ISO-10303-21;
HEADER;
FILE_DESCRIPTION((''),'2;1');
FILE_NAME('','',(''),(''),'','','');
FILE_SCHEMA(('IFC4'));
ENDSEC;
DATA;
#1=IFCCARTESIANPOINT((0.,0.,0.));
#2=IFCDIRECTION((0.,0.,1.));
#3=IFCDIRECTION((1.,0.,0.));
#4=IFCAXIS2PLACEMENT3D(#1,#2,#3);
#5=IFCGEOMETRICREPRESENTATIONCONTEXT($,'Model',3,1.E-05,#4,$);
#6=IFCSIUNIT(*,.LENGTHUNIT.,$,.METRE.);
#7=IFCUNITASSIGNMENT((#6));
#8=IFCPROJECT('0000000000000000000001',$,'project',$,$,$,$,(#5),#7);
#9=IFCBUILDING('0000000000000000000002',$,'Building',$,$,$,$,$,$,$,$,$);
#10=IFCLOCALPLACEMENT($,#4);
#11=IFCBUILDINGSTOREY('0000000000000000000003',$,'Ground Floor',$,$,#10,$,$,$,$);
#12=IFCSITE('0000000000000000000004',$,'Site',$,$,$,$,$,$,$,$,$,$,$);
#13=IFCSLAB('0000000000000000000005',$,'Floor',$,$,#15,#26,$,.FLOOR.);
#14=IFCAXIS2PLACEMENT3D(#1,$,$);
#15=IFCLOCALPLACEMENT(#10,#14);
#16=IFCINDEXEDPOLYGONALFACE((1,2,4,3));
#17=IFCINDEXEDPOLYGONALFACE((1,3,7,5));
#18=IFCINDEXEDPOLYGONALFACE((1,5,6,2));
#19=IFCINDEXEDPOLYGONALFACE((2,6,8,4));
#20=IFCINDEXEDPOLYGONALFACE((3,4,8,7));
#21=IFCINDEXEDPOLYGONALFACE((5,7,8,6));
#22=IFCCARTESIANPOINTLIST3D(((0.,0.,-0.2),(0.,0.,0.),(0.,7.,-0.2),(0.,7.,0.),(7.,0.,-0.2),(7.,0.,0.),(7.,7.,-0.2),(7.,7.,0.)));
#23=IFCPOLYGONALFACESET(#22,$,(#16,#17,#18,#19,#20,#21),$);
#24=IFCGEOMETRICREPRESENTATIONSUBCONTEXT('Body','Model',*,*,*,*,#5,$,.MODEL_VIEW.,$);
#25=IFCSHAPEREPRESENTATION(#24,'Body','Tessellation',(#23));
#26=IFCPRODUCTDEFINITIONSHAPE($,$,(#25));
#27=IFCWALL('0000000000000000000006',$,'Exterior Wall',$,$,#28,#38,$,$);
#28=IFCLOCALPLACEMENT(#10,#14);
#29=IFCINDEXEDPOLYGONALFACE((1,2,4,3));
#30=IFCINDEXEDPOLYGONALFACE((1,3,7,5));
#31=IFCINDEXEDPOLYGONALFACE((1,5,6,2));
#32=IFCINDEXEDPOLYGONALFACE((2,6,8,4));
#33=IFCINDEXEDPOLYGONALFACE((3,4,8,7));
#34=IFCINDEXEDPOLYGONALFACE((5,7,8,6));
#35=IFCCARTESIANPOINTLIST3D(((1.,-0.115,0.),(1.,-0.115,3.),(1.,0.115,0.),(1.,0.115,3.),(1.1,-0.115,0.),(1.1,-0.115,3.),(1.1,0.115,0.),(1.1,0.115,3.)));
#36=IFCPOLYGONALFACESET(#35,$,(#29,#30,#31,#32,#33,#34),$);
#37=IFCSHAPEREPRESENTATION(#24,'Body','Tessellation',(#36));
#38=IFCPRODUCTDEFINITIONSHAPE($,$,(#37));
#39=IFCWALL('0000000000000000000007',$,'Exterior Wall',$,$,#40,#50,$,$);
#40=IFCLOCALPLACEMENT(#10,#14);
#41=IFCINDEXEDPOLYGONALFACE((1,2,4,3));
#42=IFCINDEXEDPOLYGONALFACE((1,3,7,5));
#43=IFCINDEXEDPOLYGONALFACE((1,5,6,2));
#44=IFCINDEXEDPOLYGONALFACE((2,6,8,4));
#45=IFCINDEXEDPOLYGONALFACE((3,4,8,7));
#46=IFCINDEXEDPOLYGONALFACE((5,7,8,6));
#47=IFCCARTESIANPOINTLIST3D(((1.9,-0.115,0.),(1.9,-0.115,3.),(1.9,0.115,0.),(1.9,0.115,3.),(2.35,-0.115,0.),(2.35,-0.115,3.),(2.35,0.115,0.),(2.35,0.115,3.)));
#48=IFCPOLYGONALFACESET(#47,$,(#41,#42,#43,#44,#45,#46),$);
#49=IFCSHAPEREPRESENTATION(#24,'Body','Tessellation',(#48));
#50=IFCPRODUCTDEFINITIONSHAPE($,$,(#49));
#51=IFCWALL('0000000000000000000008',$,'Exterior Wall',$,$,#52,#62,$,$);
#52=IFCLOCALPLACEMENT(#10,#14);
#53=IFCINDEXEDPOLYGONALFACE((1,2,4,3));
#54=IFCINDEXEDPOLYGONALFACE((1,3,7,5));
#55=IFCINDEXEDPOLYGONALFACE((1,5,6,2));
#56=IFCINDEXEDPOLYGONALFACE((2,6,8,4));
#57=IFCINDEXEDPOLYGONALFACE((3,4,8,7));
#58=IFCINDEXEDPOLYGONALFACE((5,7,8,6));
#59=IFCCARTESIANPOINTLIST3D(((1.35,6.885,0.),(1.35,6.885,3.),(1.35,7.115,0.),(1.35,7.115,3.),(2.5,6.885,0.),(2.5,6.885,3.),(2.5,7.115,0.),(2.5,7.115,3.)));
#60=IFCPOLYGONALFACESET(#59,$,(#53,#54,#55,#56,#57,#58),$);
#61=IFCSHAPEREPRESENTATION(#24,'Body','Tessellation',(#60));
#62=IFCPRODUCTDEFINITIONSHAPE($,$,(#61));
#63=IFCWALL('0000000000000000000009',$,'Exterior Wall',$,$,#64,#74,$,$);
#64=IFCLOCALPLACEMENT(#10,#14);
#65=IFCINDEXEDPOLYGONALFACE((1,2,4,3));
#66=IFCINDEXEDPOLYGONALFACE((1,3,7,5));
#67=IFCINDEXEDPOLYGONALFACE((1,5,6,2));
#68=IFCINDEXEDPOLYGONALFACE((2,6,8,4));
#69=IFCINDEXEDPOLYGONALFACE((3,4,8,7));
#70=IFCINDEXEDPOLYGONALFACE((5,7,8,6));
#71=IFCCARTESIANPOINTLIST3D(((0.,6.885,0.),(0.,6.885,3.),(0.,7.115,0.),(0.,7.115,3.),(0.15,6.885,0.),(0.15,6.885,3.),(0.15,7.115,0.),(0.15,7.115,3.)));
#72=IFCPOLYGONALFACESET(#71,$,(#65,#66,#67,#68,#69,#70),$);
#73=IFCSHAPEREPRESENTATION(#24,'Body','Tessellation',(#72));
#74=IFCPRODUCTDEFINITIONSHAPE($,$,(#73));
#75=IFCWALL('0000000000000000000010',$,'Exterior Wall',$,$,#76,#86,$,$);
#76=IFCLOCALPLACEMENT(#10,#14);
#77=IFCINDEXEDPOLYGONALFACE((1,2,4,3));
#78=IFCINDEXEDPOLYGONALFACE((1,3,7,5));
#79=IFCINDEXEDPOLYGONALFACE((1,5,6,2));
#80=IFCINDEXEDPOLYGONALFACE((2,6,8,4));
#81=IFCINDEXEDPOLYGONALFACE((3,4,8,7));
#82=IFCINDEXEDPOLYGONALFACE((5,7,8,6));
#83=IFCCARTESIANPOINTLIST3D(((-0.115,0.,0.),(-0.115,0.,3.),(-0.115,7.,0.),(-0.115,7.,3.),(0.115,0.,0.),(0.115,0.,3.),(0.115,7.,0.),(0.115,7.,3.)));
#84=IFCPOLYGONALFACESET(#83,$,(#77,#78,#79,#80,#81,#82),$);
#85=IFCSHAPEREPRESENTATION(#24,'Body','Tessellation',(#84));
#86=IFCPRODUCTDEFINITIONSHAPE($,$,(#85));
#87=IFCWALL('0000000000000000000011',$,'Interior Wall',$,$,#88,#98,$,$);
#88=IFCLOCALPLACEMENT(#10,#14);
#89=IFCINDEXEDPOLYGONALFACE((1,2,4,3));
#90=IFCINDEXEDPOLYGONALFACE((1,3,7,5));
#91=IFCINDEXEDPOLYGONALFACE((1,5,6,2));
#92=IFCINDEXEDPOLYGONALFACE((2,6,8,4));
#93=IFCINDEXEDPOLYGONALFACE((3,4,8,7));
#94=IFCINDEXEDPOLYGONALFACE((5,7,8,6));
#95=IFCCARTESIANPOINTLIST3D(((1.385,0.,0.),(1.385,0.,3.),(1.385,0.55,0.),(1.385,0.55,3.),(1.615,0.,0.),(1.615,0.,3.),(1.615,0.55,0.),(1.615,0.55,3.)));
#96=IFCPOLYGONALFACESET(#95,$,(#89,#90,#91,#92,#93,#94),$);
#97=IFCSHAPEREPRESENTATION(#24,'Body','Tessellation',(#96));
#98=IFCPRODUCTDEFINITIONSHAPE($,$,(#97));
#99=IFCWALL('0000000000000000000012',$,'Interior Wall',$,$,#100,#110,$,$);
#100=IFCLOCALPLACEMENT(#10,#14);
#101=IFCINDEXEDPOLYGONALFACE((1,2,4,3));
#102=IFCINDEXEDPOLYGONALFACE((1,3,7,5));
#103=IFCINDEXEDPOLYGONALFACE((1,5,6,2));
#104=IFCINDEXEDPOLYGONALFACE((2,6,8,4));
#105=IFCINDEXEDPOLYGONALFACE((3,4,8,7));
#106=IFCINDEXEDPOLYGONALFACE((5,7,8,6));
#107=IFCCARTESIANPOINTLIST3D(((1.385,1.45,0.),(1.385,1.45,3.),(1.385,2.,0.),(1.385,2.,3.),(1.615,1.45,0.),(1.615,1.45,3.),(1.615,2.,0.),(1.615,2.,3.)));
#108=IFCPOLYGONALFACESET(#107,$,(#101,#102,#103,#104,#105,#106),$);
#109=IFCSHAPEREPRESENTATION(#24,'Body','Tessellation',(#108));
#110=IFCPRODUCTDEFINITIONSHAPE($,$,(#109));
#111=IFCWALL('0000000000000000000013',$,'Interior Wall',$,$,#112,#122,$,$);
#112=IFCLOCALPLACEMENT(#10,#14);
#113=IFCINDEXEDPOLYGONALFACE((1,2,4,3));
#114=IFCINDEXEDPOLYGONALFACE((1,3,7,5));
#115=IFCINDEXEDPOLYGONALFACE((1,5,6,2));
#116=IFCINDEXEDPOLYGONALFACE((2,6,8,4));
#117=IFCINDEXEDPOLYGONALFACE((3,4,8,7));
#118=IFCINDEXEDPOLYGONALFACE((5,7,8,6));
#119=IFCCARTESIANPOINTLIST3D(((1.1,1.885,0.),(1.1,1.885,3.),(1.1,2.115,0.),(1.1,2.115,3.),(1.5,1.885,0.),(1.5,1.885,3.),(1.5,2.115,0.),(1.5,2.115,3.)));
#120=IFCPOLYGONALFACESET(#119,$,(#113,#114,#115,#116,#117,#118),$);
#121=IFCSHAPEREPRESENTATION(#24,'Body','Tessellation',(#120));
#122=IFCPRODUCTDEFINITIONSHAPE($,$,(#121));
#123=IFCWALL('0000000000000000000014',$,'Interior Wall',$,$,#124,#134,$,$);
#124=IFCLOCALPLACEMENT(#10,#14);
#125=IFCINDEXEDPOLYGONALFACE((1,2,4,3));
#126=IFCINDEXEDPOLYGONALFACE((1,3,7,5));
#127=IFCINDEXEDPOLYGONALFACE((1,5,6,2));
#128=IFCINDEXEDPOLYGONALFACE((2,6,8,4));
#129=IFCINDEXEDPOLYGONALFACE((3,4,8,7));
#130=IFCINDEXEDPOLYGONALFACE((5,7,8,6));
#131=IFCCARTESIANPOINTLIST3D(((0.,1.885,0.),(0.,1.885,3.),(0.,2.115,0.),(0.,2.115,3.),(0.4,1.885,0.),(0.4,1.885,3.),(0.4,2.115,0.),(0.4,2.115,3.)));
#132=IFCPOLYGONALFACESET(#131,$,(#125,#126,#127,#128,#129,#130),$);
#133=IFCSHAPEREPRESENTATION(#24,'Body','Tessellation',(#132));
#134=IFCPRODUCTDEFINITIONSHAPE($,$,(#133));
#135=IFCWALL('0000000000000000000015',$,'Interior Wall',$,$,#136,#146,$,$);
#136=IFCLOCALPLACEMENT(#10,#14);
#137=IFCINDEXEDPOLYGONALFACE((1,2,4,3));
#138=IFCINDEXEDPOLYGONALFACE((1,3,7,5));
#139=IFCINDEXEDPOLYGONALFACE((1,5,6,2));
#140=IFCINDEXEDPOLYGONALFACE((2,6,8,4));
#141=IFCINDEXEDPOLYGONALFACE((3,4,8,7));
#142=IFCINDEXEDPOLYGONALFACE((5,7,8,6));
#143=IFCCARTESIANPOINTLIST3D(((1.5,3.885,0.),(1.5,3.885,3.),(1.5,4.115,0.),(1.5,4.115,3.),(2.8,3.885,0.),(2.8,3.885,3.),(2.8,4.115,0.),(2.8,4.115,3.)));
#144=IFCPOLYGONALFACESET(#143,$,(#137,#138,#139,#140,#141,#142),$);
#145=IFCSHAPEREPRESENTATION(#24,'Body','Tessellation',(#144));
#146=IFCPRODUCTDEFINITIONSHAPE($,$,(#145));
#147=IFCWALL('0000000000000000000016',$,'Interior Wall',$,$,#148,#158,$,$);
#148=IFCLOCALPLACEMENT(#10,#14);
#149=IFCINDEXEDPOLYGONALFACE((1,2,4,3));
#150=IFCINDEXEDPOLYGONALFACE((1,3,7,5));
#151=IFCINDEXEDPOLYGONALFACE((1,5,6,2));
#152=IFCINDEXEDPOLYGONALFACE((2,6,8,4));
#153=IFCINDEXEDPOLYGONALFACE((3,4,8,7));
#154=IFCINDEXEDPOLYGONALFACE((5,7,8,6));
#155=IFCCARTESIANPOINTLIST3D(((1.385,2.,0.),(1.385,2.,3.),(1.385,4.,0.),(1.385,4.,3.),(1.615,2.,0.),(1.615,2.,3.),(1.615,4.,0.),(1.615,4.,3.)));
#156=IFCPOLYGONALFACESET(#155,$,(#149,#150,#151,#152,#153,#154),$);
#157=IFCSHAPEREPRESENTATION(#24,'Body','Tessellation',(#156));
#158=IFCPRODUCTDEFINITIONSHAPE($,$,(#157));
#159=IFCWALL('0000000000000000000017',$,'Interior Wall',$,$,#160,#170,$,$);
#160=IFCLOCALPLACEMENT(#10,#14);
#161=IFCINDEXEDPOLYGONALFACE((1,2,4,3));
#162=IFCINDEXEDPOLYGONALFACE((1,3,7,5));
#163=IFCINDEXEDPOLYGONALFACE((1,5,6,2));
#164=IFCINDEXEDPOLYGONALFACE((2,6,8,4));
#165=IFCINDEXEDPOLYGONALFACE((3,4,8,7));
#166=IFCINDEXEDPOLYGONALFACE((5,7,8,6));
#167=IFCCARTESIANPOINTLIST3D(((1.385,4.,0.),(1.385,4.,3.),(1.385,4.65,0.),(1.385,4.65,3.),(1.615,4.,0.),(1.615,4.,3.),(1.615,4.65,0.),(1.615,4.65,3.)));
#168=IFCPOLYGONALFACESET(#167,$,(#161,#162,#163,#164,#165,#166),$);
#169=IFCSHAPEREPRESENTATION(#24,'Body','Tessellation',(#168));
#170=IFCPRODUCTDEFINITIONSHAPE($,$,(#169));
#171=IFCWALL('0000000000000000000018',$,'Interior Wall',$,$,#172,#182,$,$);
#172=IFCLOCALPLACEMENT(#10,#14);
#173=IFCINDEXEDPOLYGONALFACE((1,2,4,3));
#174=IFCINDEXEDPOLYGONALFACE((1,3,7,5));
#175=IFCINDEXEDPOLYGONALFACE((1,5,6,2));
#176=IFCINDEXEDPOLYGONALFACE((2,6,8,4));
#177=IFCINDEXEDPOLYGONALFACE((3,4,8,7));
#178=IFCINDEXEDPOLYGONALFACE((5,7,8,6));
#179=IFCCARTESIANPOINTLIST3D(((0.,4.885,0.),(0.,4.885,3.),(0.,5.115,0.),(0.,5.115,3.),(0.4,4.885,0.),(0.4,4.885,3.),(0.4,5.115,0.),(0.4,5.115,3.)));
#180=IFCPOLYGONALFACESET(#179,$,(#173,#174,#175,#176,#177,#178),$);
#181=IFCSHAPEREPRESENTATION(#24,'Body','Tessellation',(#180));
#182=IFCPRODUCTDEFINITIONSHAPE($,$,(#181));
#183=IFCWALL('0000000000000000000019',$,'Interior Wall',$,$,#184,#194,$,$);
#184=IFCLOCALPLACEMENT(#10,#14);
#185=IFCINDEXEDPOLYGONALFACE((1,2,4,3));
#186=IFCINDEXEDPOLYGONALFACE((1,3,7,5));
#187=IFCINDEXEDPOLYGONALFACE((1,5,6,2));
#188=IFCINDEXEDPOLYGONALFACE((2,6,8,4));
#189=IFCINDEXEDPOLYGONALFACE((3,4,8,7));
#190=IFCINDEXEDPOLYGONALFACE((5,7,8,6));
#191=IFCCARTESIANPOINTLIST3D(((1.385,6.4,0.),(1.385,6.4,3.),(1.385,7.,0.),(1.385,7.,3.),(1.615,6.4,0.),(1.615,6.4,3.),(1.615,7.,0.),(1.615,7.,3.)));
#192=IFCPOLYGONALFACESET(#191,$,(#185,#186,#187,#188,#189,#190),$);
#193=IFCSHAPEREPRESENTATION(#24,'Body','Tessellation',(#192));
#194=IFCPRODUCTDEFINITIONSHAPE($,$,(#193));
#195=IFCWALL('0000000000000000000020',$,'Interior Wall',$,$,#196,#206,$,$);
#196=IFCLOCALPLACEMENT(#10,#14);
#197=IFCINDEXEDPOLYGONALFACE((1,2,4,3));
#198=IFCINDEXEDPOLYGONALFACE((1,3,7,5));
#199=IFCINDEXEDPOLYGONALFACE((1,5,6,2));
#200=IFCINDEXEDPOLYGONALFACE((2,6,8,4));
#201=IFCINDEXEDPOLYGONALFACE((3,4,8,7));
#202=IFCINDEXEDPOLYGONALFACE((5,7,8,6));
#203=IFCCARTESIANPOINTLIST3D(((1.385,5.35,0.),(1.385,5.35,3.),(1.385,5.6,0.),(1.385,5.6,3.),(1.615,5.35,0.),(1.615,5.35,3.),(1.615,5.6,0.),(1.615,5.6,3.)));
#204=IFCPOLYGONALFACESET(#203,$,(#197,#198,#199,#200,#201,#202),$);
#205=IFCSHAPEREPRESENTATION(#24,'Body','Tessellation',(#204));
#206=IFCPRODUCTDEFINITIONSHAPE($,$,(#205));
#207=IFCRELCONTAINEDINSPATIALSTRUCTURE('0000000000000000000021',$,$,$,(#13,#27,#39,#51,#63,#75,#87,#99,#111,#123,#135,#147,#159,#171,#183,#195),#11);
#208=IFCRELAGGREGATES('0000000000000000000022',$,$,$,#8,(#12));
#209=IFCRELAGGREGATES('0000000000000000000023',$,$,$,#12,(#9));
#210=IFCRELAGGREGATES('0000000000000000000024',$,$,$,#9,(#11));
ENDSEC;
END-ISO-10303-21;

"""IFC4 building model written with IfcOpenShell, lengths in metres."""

from ifc_helpers import new_model, si_unit, frame, origin_with_axes, place, context, subcontext, project, spatial, indexed_curve, outline, extrude, element, save


model = new_model("IFC4")

# Units and contexts
model_context = context("Model", 3, precision=1e-05, world=origin_with_axes())
body_context = subcontext(model_context, "Body", "Model", "MODEL_VIEW")
ifc_project = project(units=[si_unit("LENGTHUNIT", "METRE")], contexts=[model_context])

# Site, building, storey
site = spatial("IfcSite", under=ifc_project, Name="Site")
building = spatial("IfcBuilding", under=site, Name="Building")
storey_placement = place(None, origin_with_axes())
storey = spatial("IfcBuildingStorey", under=building, at=storey_placement, Name="Ground Floor")

# Slab
slab_placement = place(storey_placement, frame((0.0, 0.0, -0.2), z_axis=(0.0, 0.0, 1.0), x_axis=(1.0, 0.0, 0.0)))
element("IfcSlab", 1, at=slab_placement, inside=storey, Name="Floor", PredefinedType="FLOOR", context=body_context, shape_type="SweptSolid", body=[
    extrude(outline(indexed_curve([(0.0, 0.0), (7.0, 0.0), (7.0, 7.0), (0.0, 7.0)])), None, (0.0, 0.0, 1.0), 0.2),
])

# Walls
wall_1_placement = place(storey_placement, frame((1.0, 0.0, 0.0), z_axis=(0.0, 0.0, 1.0), x_axis=(1.0, 0.0, 0.0)))
element("IfcWall", 2, at=wall_1_placement, inside=storey, Name="Exterior Wall", context=body_context, shape_type="SweptSolid", body=[
    extrude(outline(indexed_curve([(0.0, 0.0), (0.0, 0.23), (0.1, 0.23), (0.1, 0.0), (0.0, 0.0)], self_intersect=False)), frame((0.0, -0.115, 0.0), z_axis=(0.0, 0.0, 1.0), x_axis=(1.0, 0.0, 0.0)), (0.0, 0.0, 1.0), 3.0),
])
wall_2_placement = place(storey_placement, frame((1.9, 0.0, 0.0), z_axis=(0.0, 0.0, 1.0), x_axis=(1.0, 0.0, 0.0)))
element("IfcWall", 3, at=wall_2_placement, inside=storey, Name="Exterior Wall", context=body_context, shape_type="SweptSolid", body=[
    extrude(outline(indexed_curve([(0.0, 0.0), (0.0, 0.23), (0.45, 0.23), (0.45, 0.0), (0.0, 0.0)], self_intersect=False)), frame((0.0, -0.115, 0.0), z_axis=(0.0, 0.0, 1.0), x_axis=(1.0, 0.0, 0.0)), (0.0, 0.0, 1.0), 3.0),
])
wall_3_placement = place(storey_placement, frame((2.5, 7.0, 0.0), z_axis=(0.0, 0.0, 1.0), x_axis=(-1.0, 0.0, 0.0)))
element("IfcWall", 4, at=wall_3_placement, inside=storey, Name="Exterior Wall", context=body_context, shape_type="SweptSolid", body=[
    extrude(outline(indexed_curve([(0.0, 0.0), (0.0, 0.23), (1.15, 0.23), (1.15, 0.0), (0.0, 0.0)], self_intersect=False)), frame((0.0, -0.115, 0.0), z_axis=(0.0, 0.0, 1.0), x_axis=(1.0, 0.0, 0.0)), (0.0, 0.0, 1.0), 3.0),
])
wall_4_placement = place(storey_placement, frame((0.15, 7.0, 0.0), z_axis=(0.0, 0.0, 1.0), x_axis=(-1.0, 0.0, 0.0)))
element("IfcWall", 5, at=wall_4_placement, inside=storey, Name="Exterior Wall", context=body_context, shape_type="SweptSolid", body=[
    extrude(outline(indexed_curve([(0.0, 0.0), (0.0, 0.23), (0.15, 0.23), (0.15, 0.0), (0.0, 0.0)], self_intersect=False)), frame((0.0, -0.115, 0.0), z_axis=(0.0, 0.0, 1.0), x_axis=(1.0, 0.0, 0.0)), (0.0, 0.0, 1.0), 3.0),
])
wall_5_placement = place(storey_placement, frame((0.0, 7.0, 0.0), z_axis=(0.0, 0.0, 1.0), x_axis=(0.0, -1.0, 0.0)))
element("IfcWall", 6, at=wall_5_placement, inside=storey, Name="Exterior Wall", context=body_context, shape_type="SweptSolid", body=[
    extrude(outline(indexed_curve([(0.0, 0.0), (0.0, 0.23), (7.0, 0.23), (7.0, 0.0), (0.0, 0.0)], self_intersect=False)), frame((0.0, -0.115, 0.0), z_axis=(0.0, 0.0, 1.0), x_axis=(1.0, 0.0, 0.0)), (0.0, 0.0, 1.0), 3.0),
])
for number, where, z_axis, x_axis, name in (
    (7, (1.5, 0.0, 0.0), (0.0, 0.0, 1.0), (0.0, 1.0, 0.0), "Interior Wall"),
    (8, (1.5, 1.45, 0.0), (0.0, 0.0, 1.0), (0.0, 1.0, 0.0), "Interior Wall"),
):
    element("IfcWall", number, at=place(storey_placement, frame(where, z_axis=z_axis, x_axis=x_axis)), inside=storey, Name=name, context=body_context, shape_type="SweptSolid", body=[
        extrude(outline(indexed_curve([(0.0, 0.0), (0.0, 0.23), (0.55, 0.23), (0.55, 0.0), (0.0, 0.0)], self_intersect=False)), frame((0.0, -0.115, 0.0), z_axis=(0.0, 0.0, 1.0), x_axis=(1.0, 0.0, 0.0)), (0.0, 0.0, 1.0), 3.0),
    ])
for number, where, z_axis, x_axis, name in (
    (9, (1.5, 2.0, 0.0), (0.0, 0.0, 1.0), (-1.0, 0.0, 0.0), "Interior Wall"),
    (10, (0.4, 2.0, 0.0), (0.0, 0.0, 1.0), (-1.0, 0.0, 0.0), "Interior Wall"),
):
    element("IfcWall", number, at=place(storey_placement, frame(where, z_axis=z_axis, x_axis=x_axis)), inside=storey, Name=name, context=body_context, shape_type="SweptSolid", body=[
        extrude(outline(indexed_curve([(0.0, 0.0), (0.0, 0.23), (0.4, 0.23), (0.4, 0.0), (0.0, 0.0)], self_intersect=False)), frame((0.0, -0.115, 0.0), z_axis=(0.0, 0.0, 1.0), x_axis=(1.0, 0.0, 0.0)), (0.0, 0.0, 1.0), 3.0),
    ])
wall_6_placement = place(storey_placement, frame((2.8, 4.0, 0.0), z_axis=(0.0, 0.0, 1.0), x_axis=(-1.0, 0.0, 0.0)))
element("IfcWall", 11, at=wall_6_placement, inside=storey, Name="Interior Wall", context=body_context, shape_type="SweptSolid", body=[
    extrude(outline(indexed_curve([(0.0, 0.0), (0.0, 0.23), (1.3, 0.23), (1.3, 0.0), (0.0, 0.0)], self_intersect=False)), frame((0.0, -0.115, 0.0), z_axis=(0.0, 0.0, 1.0), x_axis=(1.0, 0.0, 0.0)), (0.0, 0.0, 1.0), 3.0),
])
wall_7_placement = place(storey_placement, frame((1.5, 4.0, 0.0), z_axis=(0.0, 0.0, 1.0), x_axis=(0.0, -1.0, 0.0)))
element("IfcWall", 12, at=wall_7_placement, inside=storey, Name="Interior Wall", context=body_context, shape_type="SweptSolid", body=[
    extrude(outline(indexed_curve([(0.0, 0.0), (0.0, 0.23), (2.0, 0.23), (2.0, 0.0), (0.0, 0.0)], self_intersect=False)), frame((0.0, -0.115, 0.0), z_axis=(0.0, 0.0, 1.0), x_axis=(1.0, 0.0, 0.0)), (0.0, 0.0, 1.0), 3.0),
])
wall_8_placement = place(storey_placement, frame((1.5, 4.0, 0.0), z_axis=(0.0, 0.0, 1.0), x_axis=(0.0, 1.0, 0.0)))
element("IfcWall", 13, at=wall_8_placement, inside=storey, Name="Interior Wall", context=body_context, shape_type="SweptSolid", body=[
    extrude(outline(indexed_curve([(0.0, 0.0), (0.0, 0.23), (0.65, 0.23), (0.65, 0.0), (0.0, 0.0)], self_intersect=False)), frame((0.0, -0.115, 0.0), z_axis=(0.0, 0.0, 1.0), x_axis=(1.0, 0.0, 0.0)), (0.0, 0.0, 1.0), 3.0),
])
wall_9_placement = place(storey_placement, frame((0.4, 5.0, 0.0), z_axis=(0.0, 0.0, 1.0), x_axis=(-1.0, 0.0, 0.0)))
element("IfcWall", 14, at=wall_9_placement, inside=storey, Name="Interior Wall", context=body_context, shape_type="SweptSolid", body=[
    extrude(outline(indexed_curve([(0.0, 0.0), (0.0, 0.23), (0.4, 0.23), (0.4, 0.0), (0.0, 0.0)], self_intersect=False)), frame((0.0, -0.115, 0.0), z_axis=(0.0, 0.0, 1.0), x_axis=(1.0, 0.0, 0.0)), (0.0, 0.0, 1.0), 3.0),
])
wall_10_placement = place(storey_placement, frame((1.5, 7.0, 0.0), z_axis=(0.0, 0.0, 1.0), x_axis=(0.0, -1.0, 0.0)))
element("IfcWall", 15, at=wall_10_placement, inside=storey, Name="Interior Wall", context=body_context, shape_type="SweptSolid", body=[
    extrude(outline(indexed_curve([(0.0, 0.0), (0.0, 0.23), (0.6, 0.23), (0.6, 0.0), (0.0, 0.0)], self_intersect=False)), frame((0.0, -0.115, 0.0), z_axis=(0.0, 0.0, 1.0), x_axis=(1.0, 0.0, 0.0)), (0.0, 0.0, 1.0), 3.0),
])
wall_11_placement = place(storey_placement, frame((1.5, 5.6, 0.0), z_axis=(0.0, 0.0, 1.0), x_axis=(0.0, -1.0, 0.0)))
element("IfcWall", 16, at=wall_11_placement, inside=storey, Name="Interior Wall", context=body_context, shape_type="SweptSolid", body=[
    extrude(outline(indexed_curve([(0.0, 0.0), (0.0, 0.23), (0.25, 0.23), (0.25, 0.0), (0.0, 0.0)], self_intersect=False)), frame((0.0, -0.115, 0.0), z_axis=(0.0, 0.0, 1.0), x_axis=(1.0, 0.0, 0.0)), (0.0, 0.0, 1.0), 3.0),
])

save(model, "model.ifc")
